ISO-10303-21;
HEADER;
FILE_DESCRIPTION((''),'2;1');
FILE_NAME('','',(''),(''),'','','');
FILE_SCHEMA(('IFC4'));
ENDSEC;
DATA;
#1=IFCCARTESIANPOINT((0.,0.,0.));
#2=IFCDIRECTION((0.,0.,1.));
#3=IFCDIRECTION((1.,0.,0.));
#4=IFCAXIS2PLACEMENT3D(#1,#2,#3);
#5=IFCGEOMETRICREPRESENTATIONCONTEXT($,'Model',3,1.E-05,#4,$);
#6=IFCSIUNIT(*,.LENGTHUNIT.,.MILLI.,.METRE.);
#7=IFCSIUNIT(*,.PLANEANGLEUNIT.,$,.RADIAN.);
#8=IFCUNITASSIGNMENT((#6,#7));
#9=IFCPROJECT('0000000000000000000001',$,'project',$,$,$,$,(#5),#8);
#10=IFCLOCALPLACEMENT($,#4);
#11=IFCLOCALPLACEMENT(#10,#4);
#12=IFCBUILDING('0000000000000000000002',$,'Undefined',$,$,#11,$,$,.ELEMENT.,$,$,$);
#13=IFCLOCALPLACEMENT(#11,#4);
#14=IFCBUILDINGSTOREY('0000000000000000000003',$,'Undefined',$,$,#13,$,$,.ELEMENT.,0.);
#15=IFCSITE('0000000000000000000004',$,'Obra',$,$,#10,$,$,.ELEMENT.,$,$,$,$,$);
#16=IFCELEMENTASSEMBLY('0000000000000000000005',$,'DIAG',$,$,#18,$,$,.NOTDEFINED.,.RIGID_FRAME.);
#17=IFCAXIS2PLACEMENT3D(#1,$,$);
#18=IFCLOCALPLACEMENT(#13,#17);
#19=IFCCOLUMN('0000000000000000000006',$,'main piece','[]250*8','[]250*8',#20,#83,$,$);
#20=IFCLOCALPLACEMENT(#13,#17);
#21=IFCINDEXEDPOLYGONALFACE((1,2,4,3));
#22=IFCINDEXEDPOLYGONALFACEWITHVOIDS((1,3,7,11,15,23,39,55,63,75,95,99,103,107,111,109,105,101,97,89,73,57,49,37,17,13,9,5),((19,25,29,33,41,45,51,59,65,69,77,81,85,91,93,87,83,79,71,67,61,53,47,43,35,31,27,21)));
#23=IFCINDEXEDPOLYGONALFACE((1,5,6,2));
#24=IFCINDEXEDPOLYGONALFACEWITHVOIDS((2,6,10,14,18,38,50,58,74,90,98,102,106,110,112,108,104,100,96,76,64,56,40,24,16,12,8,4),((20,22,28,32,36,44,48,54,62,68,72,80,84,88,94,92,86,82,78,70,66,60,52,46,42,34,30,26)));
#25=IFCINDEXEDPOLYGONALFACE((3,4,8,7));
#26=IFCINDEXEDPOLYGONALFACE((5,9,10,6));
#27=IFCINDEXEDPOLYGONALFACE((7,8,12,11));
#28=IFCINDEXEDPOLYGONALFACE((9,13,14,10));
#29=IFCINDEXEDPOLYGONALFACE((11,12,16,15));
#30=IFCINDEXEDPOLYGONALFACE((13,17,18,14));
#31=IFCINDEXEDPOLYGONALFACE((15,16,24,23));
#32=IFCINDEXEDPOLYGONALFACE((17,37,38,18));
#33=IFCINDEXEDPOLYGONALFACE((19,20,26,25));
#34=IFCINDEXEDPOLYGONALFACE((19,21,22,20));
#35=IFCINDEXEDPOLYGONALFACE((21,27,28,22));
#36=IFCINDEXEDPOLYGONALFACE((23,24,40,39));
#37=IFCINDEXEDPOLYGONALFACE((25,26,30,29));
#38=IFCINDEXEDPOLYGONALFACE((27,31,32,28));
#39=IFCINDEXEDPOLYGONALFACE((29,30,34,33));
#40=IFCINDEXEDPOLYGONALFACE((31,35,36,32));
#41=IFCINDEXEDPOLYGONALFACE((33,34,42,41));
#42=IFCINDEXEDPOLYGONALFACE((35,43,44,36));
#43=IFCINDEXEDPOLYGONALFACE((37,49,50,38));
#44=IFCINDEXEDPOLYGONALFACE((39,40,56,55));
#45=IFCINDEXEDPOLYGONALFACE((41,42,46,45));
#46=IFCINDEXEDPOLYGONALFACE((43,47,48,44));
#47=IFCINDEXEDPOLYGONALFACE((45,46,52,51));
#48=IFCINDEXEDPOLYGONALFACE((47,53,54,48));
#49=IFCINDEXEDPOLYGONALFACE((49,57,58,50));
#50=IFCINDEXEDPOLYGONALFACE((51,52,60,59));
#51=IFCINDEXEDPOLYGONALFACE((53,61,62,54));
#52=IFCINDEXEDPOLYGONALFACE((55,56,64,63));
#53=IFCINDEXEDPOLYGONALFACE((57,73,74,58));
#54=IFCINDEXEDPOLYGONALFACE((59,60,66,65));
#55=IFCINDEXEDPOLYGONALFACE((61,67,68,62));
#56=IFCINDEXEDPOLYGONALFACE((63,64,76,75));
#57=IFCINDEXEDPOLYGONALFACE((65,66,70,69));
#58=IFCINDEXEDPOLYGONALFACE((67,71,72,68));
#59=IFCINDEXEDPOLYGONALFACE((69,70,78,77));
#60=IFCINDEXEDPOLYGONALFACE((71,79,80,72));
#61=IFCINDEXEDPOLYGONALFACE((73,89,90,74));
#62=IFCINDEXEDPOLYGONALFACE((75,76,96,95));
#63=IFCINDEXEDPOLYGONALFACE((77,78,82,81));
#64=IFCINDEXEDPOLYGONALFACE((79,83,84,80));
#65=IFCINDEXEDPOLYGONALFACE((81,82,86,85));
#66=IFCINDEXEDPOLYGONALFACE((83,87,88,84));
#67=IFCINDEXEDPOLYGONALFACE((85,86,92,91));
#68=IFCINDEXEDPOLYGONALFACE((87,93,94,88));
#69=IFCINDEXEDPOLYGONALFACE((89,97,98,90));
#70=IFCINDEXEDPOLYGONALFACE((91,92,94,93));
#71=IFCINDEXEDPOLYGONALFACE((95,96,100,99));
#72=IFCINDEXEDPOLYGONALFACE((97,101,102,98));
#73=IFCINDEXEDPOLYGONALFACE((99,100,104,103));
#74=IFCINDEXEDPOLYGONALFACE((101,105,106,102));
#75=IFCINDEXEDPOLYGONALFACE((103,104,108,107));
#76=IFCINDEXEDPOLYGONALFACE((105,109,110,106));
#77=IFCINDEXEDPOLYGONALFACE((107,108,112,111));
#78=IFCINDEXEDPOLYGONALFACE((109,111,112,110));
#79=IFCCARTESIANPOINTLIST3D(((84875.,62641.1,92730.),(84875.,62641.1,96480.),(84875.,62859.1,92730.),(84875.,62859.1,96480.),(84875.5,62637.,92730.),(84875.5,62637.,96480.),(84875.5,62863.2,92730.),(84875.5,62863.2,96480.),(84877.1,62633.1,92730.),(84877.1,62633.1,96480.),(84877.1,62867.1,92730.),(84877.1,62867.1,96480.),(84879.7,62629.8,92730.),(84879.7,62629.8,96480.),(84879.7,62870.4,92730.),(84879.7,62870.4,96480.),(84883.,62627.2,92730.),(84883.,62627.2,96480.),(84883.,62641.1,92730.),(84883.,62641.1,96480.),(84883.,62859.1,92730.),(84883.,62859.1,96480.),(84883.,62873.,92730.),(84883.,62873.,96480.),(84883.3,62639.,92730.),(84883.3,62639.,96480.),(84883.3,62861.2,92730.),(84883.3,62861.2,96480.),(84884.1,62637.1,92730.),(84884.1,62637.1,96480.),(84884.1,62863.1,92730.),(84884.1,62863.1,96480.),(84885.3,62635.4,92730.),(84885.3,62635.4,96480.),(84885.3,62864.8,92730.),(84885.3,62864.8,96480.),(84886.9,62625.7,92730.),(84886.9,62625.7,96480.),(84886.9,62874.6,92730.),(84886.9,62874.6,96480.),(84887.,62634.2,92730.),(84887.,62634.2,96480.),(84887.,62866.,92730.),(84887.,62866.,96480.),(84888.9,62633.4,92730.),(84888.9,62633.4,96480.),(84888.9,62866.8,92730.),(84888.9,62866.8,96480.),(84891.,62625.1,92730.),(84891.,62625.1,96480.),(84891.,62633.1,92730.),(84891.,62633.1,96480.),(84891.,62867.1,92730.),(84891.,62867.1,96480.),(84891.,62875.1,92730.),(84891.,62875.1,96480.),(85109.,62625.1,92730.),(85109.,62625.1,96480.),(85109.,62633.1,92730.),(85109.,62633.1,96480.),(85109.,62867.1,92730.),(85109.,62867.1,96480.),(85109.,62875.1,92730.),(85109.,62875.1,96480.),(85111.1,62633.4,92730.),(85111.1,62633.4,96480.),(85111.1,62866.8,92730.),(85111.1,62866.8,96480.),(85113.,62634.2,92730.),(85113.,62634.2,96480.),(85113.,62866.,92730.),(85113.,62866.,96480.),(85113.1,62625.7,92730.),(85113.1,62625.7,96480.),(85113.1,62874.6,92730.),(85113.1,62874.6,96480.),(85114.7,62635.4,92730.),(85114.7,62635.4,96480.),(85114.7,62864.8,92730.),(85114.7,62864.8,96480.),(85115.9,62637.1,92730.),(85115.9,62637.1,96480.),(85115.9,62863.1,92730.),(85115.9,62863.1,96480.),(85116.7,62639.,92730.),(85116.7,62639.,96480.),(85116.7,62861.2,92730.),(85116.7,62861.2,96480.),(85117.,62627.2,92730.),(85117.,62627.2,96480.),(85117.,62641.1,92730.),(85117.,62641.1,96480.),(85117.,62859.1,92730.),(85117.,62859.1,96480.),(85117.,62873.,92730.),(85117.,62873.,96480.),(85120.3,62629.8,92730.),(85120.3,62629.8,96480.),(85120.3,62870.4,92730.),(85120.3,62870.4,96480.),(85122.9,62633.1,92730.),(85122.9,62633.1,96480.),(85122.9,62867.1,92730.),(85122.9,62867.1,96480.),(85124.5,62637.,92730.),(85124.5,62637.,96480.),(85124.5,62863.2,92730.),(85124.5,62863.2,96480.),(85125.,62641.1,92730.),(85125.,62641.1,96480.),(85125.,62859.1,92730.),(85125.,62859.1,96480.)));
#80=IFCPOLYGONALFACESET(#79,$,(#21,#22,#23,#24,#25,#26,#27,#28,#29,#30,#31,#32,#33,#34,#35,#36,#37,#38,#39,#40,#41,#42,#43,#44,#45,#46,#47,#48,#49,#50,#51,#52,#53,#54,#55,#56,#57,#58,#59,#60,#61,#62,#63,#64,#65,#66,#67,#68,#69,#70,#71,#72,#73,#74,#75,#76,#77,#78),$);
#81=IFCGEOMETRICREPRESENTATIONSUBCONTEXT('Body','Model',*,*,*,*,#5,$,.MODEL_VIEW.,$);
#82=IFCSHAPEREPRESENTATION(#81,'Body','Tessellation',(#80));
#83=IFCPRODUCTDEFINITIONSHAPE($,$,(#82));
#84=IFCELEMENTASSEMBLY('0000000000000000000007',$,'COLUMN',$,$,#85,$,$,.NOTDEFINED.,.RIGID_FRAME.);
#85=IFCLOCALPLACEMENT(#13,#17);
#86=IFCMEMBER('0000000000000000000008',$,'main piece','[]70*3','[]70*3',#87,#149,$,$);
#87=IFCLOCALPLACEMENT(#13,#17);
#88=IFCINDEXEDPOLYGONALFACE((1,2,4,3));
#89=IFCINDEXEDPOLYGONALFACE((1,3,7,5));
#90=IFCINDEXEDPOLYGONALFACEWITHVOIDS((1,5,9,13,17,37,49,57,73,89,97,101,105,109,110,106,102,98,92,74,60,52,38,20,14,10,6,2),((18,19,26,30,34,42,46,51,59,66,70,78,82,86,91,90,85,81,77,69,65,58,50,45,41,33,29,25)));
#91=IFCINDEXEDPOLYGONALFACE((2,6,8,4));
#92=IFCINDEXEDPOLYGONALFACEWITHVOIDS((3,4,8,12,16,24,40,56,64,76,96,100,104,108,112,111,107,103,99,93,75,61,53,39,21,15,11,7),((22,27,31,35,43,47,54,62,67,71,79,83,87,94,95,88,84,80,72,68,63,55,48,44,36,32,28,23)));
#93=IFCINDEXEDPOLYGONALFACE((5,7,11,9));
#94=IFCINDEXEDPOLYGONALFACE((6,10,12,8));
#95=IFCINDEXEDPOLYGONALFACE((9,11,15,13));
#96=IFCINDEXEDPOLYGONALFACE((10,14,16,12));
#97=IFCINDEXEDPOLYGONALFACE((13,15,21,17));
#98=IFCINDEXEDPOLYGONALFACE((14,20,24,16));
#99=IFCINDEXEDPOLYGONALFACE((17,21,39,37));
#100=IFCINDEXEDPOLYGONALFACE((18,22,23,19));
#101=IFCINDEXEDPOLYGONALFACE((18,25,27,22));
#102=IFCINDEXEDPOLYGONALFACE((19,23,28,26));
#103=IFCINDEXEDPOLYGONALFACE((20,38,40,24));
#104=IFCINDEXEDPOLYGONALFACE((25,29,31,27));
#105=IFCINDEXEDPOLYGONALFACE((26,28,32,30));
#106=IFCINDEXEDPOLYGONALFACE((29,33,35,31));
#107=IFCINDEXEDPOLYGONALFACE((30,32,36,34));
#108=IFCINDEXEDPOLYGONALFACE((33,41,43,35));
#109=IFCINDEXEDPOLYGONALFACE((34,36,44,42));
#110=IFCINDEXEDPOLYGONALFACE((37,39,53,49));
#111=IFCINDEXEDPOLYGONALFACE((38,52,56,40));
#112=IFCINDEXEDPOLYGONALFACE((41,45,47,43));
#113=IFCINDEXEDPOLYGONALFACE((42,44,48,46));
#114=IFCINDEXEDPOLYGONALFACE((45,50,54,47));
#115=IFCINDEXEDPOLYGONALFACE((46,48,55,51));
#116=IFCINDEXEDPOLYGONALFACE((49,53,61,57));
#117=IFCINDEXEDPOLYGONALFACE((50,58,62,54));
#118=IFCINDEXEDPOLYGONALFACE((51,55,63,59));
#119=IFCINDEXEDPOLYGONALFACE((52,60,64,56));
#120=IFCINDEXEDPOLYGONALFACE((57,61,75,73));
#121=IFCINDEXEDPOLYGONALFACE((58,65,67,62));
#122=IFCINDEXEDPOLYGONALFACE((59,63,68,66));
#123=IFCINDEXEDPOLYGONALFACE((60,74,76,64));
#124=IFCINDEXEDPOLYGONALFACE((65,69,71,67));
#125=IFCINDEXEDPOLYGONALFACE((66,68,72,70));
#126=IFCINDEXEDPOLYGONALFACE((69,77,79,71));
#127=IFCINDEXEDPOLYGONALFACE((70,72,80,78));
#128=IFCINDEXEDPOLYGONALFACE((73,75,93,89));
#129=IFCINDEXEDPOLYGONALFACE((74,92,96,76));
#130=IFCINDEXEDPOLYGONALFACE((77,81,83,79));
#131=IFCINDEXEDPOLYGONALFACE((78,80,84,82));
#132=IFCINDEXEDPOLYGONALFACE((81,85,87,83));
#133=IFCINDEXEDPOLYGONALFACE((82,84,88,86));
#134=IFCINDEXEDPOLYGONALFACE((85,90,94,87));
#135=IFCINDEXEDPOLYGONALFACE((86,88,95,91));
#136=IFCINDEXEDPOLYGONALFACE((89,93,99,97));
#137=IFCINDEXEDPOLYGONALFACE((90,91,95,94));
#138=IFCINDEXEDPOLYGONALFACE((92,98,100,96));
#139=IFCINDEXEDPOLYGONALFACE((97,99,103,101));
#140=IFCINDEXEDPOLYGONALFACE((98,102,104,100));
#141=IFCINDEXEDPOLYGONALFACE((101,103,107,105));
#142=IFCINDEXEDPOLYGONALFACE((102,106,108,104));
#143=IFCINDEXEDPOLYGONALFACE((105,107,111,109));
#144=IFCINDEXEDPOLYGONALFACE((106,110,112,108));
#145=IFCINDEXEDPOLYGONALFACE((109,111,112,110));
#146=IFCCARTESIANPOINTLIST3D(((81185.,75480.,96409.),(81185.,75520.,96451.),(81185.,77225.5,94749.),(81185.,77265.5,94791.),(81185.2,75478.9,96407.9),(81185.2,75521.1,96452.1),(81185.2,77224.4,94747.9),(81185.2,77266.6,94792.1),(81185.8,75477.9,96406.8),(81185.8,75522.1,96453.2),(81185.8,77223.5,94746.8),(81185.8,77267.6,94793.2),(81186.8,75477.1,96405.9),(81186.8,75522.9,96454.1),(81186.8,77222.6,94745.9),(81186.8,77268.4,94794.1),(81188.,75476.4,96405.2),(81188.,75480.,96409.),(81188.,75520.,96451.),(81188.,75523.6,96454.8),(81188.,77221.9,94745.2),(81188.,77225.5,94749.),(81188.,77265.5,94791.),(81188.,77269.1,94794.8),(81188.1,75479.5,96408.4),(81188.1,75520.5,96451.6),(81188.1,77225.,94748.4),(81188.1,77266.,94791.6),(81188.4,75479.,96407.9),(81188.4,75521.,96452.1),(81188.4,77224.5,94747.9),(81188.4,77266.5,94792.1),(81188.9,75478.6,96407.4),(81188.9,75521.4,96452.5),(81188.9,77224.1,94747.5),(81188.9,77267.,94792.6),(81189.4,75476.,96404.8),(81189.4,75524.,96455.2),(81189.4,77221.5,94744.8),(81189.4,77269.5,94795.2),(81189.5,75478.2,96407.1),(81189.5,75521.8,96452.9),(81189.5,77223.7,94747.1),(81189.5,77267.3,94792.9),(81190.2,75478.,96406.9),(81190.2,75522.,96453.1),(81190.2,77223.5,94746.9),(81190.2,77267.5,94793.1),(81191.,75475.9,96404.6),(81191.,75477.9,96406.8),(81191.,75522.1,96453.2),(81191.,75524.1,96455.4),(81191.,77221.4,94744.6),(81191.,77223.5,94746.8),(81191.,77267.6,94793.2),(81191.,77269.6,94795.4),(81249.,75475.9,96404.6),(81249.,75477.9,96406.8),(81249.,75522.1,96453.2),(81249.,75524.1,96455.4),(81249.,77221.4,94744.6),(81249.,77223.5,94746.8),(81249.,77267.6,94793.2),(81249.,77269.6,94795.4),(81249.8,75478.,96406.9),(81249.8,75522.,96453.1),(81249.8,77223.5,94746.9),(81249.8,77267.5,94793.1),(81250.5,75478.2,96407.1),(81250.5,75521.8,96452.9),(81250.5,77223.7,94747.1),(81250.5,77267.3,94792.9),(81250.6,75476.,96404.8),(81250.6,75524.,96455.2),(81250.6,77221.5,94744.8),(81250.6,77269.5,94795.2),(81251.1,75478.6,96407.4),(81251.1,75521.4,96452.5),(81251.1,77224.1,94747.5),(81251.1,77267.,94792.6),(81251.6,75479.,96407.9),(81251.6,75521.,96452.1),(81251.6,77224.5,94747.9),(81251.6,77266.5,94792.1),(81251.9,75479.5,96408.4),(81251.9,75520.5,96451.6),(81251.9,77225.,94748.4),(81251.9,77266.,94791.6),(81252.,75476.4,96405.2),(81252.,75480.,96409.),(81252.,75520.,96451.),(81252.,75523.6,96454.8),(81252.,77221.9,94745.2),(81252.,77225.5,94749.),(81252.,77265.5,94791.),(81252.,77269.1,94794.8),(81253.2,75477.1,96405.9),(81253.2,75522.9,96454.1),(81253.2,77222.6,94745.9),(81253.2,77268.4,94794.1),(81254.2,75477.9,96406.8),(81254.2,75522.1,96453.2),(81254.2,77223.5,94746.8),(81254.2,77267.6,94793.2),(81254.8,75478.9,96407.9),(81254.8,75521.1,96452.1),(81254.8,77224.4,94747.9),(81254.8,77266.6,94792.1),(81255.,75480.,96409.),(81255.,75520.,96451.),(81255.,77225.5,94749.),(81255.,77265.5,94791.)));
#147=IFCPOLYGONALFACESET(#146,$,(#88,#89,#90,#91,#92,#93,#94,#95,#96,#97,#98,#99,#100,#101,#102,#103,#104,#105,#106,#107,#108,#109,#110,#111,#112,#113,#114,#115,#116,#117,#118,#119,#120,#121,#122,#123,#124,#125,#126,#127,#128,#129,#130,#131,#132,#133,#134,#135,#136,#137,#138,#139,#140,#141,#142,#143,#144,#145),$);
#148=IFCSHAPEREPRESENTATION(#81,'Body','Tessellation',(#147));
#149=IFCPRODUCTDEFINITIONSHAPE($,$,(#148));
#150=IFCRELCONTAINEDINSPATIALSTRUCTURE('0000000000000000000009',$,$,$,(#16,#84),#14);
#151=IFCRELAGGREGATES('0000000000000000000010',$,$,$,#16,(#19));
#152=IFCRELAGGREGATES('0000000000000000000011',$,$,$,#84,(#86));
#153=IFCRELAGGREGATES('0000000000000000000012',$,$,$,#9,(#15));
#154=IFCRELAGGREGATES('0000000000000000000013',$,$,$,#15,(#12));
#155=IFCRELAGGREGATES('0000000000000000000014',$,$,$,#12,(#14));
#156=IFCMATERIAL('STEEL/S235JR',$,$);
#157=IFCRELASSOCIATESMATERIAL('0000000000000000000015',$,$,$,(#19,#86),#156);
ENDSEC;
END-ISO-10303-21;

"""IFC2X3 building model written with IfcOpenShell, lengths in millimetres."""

from ifc_helpers import new_model, si_unit, frame, origin_with_axes, origin_2d_with_axis, place, context, subcontext, project, spatial, hollow_rectangle, extrude, material, element, aggregate, save


model = new_model("IFC2X3")

# Units and contexts
model_context = context("Model", 3, precision=1e-05, world=origin_with_axes())
body_context = subcontext(model_context, "Body", "Model", "MODEL_VIEW")
ifc_project = project(units=[si_unit("LENGTHUNIT", "METRE", prefix="MILLI"), si_unit("PLANEANGLEUNIT", "RADIAN")], contexts=[model_context])

# Site, building, storey
site_placement = place(None, origin_with_axes())
site = spatial("IfcSite", under=ifc_project, at=site_placement, Name="Obra", CompositionType="ELEMENT")
building_placement = place(site_placement, origin_with_axes())
building = spatial("IfcBuilding", under=site, at=building_placement, Name="Undefined", CompositionType="ELEMENT")
storey_placement = place(building_placement, origin_with_axes())
storey = spatial("IfcBuildingStorey", under=building, at=storey_placement, Name="Undefined", CompositionType="ELEMENT", Elevation=0.0)

# Element assembly, column
ifc_material = material(Name="STEEL/S235JR")
assembly_1_placement = place(storey_placement, origin_with_axes())
assembly_1 = element("IfcElementAssembly", 1, at=assembly_1_placement, inside=storey, Name="DIAG", AssemblyPlace="NOTDEFINED", PredefinedType="RIGID_FRAME")
column_1_placement = place(assembly_1_placement, frame((85000.0, 62750.1, 92730.0), z_axis=(0.0, 0.0, 1.0), x_axis=(-1.0, 0.0, 0.0)))
column_1 = element("IfcColumn", 2, at=column_1_placement, material=ifc_material, Name="main piece", Description="[]250*8", ObjectType="[]250*8", context=body_context, shape_type="SweptSolid", body=[
    extrude(hollow_rectangle(XDim=250.0, YDim=250.0, WallThickness=8.0, InnerFilletRadius=8.0, OuterFilletRadius=16.0, at=origin_2d_with_axis()), frame((0.0, 0.0, 3750.0), z_axis=(0.0, 0.0, -1.0), x_axis=(0.0, 1.0, 0.0)), (0.0, 0.0, 1.0), 3750.0),
])
aggregate(assembly_1, [column_1])

# Element assembly, member
assembly_2_placement = place(storey_placement, origin_with_axes())
assembly_2 = element("IfcElementAssembly", 3, at=assembly_2_placement, inside=storey, Name="COLUMN", AssemblyPlace="NOTDEFINED", PredefinedType="RIGID_FRAME")
member_1_placement = place(assembly_2_placement, frame((81220.0, 77245.5, 94770.0), z_axis=(1.0, 0.0, 0.0), x_axis=(0.0, -0.724633, 0.689135)))
member_1 = element("IfcMember", 4, at=member_1_placement, material=ifc_material, Name="main piece", Description="[]70*3", ObjectType="[]70*3", context=body_context, shape_type="SweptSolid", body=[
    extrude(hollow_rectangle(XDim=70.0, YDim=70.0, WallThickness=3.0, InnerFilletRadius=3.0, OuterFilletRadius=6.0, at=origin_2d_with_axis()), frame((2408.8, 0.0, 0.0), z_axis=(-1.0, 0.0, 0.0), x_axis=(0.0, -1.0, 0.0)), (0.0, 0.0, 1.0), 2408.8),
])
aggregate(assembly_2, [member_1])

save(model, "model.ifc")
